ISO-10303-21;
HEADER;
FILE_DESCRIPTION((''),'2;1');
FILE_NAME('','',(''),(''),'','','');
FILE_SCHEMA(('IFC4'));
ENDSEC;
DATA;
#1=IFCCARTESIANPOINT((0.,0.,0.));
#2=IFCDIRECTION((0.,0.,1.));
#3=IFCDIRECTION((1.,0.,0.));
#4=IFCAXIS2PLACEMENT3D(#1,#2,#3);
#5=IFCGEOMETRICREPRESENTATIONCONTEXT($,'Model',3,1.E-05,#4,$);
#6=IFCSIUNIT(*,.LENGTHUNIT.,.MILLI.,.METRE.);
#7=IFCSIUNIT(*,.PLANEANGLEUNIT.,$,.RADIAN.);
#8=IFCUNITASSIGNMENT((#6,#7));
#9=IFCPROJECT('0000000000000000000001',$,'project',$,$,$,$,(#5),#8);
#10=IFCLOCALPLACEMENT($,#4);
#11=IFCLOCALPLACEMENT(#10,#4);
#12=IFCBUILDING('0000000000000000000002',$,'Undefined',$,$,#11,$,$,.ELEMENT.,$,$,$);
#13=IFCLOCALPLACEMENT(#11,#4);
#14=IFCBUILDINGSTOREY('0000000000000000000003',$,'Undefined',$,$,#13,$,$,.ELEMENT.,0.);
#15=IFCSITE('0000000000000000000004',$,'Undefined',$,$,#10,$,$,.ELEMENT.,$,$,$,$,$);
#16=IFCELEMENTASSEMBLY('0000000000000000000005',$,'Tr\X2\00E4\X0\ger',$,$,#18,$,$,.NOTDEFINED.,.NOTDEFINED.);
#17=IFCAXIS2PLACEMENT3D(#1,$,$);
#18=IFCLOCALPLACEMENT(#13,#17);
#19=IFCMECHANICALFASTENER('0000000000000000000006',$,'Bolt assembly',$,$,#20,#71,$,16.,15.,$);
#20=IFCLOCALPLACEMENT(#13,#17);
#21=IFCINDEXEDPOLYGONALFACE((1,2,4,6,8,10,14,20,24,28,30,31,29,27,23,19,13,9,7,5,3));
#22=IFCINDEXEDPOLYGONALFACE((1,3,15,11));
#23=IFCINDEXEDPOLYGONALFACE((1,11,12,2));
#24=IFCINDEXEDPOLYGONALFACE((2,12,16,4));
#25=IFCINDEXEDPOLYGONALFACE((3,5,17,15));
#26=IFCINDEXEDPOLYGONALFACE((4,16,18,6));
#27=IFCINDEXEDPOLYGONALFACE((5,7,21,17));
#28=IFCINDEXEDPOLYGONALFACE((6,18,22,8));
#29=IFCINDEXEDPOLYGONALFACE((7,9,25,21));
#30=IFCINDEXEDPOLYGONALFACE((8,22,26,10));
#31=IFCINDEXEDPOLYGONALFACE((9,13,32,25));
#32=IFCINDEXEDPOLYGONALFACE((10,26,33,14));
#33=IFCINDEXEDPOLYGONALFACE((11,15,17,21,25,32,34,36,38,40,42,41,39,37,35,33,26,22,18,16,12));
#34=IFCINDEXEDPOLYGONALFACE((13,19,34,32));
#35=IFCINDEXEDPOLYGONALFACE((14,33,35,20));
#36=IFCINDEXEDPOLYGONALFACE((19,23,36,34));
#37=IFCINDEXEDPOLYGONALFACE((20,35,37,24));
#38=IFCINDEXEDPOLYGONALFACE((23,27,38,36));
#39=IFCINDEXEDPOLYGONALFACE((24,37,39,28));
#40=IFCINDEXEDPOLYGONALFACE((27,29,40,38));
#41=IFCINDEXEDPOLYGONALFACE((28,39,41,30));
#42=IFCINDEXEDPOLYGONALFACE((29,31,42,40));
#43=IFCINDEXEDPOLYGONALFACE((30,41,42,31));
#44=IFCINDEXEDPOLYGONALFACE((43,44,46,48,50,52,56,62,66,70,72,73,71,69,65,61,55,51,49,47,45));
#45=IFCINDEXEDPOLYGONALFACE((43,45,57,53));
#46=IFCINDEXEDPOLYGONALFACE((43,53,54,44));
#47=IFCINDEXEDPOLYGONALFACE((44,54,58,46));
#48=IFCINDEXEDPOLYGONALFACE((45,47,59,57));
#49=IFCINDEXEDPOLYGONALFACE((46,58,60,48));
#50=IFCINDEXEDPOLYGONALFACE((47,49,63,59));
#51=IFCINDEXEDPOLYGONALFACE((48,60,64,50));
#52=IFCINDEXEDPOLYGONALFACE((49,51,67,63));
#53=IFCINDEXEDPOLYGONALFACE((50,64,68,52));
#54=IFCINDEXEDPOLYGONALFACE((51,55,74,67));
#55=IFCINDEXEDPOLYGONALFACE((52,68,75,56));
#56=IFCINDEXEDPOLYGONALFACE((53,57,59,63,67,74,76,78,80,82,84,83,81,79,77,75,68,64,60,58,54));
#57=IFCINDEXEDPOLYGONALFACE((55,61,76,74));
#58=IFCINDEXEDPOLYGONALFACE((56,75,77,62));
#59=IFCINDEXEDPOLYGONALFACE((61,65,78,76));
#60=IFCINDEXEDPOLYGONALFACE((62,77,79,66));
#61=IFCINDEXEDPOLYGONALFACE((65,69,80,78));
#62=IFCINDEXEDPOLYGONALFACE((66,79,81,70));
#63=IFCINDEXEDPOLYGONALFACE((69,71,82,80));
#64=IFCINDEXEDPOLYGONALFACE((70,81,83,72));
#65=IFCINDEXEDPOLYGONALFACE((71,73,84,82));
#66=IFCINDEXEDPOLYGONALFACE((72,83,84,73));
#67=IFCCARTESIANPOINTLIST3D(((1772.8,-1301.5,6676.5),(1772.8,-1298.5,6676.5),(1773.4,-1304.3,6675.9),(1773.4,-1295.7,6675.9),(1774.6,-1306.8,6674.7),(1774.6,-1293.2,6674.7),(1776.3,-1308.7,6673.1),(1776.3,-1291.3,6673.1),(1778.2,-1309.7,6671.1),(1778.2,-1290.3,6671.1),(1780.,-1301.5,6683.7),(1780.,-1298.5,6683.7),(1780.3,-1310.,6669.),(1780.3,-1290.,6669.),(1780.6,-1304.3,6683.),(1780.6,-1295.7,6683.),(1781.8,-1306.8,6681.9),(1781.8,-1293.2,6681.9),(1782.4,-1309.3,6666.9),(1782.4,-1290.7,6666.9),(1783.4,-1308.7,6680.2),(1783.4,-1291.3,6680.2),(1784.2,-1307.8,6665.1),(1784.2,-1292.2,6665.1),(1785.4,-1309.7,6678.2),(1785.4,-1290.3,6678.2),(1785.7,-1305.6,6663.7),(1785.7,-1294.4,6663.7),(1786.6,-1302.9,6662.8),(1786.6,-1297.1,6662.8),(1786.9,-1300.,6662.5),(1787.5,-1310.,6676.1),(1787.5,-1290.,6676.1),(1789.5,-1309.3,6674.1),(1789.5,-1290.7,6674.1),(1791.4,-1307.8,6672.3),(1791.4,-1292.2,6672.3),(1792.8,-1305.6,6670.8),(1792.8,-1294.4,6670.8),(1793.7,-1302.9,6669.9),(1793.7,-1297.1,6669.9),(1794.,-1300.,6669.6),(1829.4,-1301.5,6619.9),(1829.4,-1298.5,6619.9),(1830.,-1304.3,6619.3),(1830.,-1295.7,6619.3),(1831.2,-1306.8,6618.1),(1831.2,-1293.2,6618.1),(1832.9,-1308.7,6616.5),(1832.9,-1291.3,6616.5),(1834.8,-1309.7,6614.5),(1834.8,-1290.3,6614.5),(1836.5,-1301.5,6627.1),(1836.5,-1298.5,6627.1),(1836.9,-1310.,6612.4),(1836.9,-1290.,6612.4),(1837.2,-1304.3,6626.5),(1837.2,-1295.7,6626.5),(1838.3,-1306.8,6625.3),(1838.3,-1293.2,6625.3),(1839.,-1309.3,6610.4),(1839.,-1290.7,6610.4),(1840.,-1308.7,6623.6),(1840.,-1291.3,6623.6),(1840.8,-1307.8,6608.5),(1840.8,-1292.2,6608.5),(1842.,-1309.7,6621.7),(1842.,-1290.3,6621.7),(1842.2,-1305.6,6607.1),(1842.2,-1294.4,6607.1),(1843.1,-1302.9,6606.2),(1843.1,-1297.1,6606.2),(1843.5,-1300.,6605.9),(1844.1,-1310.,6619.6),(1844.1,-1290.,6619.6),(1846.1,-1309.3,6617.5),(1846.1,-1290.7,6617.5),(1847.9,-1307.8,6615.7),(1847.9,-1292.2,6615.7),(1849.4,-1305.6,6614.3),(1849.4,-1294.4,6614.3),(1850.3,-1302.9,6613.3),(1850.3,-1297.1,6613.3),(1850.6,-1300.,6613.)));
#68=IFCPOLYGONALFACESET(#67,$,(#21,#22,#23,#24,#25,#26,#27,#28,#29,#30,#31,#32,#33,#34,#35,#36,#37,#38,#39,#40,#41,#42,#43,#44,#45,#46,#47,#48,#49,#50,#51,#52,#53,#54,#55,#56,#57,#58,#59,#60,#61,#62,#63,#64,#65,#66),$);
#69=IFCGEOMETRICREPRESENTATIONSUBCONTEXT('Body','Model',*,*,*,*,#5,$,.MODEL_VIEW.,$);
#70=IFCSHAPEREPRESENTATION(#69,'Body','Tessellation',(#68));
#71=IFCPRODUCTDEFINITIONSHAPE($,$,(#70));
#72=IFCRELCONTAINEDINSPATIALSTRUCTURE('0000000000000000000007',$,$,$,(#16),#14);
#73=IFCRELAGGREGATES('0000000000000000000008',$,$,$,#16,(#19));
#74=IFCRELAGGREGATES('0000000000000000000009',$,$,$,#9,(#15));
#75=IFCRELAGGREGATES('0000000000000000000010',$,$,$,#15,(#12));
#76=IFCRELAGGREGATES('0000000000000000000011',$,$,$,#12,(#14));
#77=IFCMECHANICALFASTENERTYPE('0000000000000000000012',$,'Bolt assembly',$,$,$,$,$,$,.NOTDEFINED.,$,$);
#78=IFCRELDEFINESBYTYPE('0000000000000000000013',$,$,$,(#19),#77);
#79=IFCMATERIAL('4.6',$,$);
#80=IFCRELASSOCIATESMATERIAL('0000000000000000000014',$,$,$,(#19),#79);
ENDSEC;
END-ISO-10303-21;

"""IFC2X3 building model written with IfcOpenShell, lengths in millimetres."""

from ifc_helpers import new_model, si_unit, frame, origin_with_axes, origin_2d_with_axis, place, context, subcontext, project, spatial, circle, extrude, source, transform, mapped, material, type_object, element, aggregate, save


model = new_model("IFC2X3")

# Units and contexts
model_context = context("Model", 3, precision=1e-05, world=origin_with_axes())
body_context = subcontext(model_context, "Body", "Model", "MODEL_VIEW")
ifc_project = project(units=[si_unit("LENGTHUNIT", "METRE", prefix="MILLI"), si_unit("PLANEANGLEUNIT", "RADIAN")], contexts=[model_context])

# Site, building, storey
site_placement = place(None, origin_with_axes())
site = spatial("IfcSite", under=ifc_project, at=site_placement, Name="Undefined", CompositionType="ELEMENT")
building_placement = place(site_placement, origin_with_axes())
building = spatial("IfcBuilding", under=site, at=building_placement, Name="Undefined", CompositionType="ELEMENT")
storey_placement = place(building_placement, origin_with_axes())
storey = spatial("IfcBuildingStorey", under=building, at=storey_placement, Name="Undefined", CompositionType="ELEMENT", Elevation=0.0)

# Element assembly
assembly_1_placement = place(storey_placement, origin_with_axes())
assembly_1 = element("IfcElementAssembly", 1, at=assembly_1_placement, inside=storey, Name="Träger", AssemblyPlace="NOTDEFINED", PredefinedType="NOTDEFINED")

# Mechanical fastener
ifc_material_1 = material(Name="4.6")
mechanical_fastener_type = type_object("IfcMechanicalFastenerType", Name="Bolt assembly")
shared_shape_1 = source(origin_with_axes(), body_context, "Body", "SweptSolid", [
    extrude(circle(Radius=10.0, at=origin_2d_with_axis()), frame((0.0, 0.0, 0.0), z_axis=(0.0, 1.0, 0.0), x_axis=(1.0, 0.0, 0.0)), (0.0, 0.0, 1.0), 10.1),
])
mechanical_fastener_1_placement = place(assembly_1_placement, frame((1787.0, -1300.0, 6676.7), z_axis=(0.0, 1.0, 0.0), x_axis=(0.707107, 0.0, -0.707107)))
mechanical_fastener_1 = element("IfcMechanicalFastener", 2, at=mechanical_fastener_1_placement, type_object=mechanical_fastener_type, material=ifc_material_1, Name="Bolt assembly", NominalDiameter=16.0, NominalLength=15.0, context=body_context, shape_type="MappedRepresentation", body=[
    mapped(shared_shape_1, transform((0.0, 0.0, 0.0))),
    mapped(shared_shape_1, transform((80.0, 0.0, 0.0))),
])
aggregate(assembly_1, [mechanical_fastener_1])

save(model, "model.ifc")
